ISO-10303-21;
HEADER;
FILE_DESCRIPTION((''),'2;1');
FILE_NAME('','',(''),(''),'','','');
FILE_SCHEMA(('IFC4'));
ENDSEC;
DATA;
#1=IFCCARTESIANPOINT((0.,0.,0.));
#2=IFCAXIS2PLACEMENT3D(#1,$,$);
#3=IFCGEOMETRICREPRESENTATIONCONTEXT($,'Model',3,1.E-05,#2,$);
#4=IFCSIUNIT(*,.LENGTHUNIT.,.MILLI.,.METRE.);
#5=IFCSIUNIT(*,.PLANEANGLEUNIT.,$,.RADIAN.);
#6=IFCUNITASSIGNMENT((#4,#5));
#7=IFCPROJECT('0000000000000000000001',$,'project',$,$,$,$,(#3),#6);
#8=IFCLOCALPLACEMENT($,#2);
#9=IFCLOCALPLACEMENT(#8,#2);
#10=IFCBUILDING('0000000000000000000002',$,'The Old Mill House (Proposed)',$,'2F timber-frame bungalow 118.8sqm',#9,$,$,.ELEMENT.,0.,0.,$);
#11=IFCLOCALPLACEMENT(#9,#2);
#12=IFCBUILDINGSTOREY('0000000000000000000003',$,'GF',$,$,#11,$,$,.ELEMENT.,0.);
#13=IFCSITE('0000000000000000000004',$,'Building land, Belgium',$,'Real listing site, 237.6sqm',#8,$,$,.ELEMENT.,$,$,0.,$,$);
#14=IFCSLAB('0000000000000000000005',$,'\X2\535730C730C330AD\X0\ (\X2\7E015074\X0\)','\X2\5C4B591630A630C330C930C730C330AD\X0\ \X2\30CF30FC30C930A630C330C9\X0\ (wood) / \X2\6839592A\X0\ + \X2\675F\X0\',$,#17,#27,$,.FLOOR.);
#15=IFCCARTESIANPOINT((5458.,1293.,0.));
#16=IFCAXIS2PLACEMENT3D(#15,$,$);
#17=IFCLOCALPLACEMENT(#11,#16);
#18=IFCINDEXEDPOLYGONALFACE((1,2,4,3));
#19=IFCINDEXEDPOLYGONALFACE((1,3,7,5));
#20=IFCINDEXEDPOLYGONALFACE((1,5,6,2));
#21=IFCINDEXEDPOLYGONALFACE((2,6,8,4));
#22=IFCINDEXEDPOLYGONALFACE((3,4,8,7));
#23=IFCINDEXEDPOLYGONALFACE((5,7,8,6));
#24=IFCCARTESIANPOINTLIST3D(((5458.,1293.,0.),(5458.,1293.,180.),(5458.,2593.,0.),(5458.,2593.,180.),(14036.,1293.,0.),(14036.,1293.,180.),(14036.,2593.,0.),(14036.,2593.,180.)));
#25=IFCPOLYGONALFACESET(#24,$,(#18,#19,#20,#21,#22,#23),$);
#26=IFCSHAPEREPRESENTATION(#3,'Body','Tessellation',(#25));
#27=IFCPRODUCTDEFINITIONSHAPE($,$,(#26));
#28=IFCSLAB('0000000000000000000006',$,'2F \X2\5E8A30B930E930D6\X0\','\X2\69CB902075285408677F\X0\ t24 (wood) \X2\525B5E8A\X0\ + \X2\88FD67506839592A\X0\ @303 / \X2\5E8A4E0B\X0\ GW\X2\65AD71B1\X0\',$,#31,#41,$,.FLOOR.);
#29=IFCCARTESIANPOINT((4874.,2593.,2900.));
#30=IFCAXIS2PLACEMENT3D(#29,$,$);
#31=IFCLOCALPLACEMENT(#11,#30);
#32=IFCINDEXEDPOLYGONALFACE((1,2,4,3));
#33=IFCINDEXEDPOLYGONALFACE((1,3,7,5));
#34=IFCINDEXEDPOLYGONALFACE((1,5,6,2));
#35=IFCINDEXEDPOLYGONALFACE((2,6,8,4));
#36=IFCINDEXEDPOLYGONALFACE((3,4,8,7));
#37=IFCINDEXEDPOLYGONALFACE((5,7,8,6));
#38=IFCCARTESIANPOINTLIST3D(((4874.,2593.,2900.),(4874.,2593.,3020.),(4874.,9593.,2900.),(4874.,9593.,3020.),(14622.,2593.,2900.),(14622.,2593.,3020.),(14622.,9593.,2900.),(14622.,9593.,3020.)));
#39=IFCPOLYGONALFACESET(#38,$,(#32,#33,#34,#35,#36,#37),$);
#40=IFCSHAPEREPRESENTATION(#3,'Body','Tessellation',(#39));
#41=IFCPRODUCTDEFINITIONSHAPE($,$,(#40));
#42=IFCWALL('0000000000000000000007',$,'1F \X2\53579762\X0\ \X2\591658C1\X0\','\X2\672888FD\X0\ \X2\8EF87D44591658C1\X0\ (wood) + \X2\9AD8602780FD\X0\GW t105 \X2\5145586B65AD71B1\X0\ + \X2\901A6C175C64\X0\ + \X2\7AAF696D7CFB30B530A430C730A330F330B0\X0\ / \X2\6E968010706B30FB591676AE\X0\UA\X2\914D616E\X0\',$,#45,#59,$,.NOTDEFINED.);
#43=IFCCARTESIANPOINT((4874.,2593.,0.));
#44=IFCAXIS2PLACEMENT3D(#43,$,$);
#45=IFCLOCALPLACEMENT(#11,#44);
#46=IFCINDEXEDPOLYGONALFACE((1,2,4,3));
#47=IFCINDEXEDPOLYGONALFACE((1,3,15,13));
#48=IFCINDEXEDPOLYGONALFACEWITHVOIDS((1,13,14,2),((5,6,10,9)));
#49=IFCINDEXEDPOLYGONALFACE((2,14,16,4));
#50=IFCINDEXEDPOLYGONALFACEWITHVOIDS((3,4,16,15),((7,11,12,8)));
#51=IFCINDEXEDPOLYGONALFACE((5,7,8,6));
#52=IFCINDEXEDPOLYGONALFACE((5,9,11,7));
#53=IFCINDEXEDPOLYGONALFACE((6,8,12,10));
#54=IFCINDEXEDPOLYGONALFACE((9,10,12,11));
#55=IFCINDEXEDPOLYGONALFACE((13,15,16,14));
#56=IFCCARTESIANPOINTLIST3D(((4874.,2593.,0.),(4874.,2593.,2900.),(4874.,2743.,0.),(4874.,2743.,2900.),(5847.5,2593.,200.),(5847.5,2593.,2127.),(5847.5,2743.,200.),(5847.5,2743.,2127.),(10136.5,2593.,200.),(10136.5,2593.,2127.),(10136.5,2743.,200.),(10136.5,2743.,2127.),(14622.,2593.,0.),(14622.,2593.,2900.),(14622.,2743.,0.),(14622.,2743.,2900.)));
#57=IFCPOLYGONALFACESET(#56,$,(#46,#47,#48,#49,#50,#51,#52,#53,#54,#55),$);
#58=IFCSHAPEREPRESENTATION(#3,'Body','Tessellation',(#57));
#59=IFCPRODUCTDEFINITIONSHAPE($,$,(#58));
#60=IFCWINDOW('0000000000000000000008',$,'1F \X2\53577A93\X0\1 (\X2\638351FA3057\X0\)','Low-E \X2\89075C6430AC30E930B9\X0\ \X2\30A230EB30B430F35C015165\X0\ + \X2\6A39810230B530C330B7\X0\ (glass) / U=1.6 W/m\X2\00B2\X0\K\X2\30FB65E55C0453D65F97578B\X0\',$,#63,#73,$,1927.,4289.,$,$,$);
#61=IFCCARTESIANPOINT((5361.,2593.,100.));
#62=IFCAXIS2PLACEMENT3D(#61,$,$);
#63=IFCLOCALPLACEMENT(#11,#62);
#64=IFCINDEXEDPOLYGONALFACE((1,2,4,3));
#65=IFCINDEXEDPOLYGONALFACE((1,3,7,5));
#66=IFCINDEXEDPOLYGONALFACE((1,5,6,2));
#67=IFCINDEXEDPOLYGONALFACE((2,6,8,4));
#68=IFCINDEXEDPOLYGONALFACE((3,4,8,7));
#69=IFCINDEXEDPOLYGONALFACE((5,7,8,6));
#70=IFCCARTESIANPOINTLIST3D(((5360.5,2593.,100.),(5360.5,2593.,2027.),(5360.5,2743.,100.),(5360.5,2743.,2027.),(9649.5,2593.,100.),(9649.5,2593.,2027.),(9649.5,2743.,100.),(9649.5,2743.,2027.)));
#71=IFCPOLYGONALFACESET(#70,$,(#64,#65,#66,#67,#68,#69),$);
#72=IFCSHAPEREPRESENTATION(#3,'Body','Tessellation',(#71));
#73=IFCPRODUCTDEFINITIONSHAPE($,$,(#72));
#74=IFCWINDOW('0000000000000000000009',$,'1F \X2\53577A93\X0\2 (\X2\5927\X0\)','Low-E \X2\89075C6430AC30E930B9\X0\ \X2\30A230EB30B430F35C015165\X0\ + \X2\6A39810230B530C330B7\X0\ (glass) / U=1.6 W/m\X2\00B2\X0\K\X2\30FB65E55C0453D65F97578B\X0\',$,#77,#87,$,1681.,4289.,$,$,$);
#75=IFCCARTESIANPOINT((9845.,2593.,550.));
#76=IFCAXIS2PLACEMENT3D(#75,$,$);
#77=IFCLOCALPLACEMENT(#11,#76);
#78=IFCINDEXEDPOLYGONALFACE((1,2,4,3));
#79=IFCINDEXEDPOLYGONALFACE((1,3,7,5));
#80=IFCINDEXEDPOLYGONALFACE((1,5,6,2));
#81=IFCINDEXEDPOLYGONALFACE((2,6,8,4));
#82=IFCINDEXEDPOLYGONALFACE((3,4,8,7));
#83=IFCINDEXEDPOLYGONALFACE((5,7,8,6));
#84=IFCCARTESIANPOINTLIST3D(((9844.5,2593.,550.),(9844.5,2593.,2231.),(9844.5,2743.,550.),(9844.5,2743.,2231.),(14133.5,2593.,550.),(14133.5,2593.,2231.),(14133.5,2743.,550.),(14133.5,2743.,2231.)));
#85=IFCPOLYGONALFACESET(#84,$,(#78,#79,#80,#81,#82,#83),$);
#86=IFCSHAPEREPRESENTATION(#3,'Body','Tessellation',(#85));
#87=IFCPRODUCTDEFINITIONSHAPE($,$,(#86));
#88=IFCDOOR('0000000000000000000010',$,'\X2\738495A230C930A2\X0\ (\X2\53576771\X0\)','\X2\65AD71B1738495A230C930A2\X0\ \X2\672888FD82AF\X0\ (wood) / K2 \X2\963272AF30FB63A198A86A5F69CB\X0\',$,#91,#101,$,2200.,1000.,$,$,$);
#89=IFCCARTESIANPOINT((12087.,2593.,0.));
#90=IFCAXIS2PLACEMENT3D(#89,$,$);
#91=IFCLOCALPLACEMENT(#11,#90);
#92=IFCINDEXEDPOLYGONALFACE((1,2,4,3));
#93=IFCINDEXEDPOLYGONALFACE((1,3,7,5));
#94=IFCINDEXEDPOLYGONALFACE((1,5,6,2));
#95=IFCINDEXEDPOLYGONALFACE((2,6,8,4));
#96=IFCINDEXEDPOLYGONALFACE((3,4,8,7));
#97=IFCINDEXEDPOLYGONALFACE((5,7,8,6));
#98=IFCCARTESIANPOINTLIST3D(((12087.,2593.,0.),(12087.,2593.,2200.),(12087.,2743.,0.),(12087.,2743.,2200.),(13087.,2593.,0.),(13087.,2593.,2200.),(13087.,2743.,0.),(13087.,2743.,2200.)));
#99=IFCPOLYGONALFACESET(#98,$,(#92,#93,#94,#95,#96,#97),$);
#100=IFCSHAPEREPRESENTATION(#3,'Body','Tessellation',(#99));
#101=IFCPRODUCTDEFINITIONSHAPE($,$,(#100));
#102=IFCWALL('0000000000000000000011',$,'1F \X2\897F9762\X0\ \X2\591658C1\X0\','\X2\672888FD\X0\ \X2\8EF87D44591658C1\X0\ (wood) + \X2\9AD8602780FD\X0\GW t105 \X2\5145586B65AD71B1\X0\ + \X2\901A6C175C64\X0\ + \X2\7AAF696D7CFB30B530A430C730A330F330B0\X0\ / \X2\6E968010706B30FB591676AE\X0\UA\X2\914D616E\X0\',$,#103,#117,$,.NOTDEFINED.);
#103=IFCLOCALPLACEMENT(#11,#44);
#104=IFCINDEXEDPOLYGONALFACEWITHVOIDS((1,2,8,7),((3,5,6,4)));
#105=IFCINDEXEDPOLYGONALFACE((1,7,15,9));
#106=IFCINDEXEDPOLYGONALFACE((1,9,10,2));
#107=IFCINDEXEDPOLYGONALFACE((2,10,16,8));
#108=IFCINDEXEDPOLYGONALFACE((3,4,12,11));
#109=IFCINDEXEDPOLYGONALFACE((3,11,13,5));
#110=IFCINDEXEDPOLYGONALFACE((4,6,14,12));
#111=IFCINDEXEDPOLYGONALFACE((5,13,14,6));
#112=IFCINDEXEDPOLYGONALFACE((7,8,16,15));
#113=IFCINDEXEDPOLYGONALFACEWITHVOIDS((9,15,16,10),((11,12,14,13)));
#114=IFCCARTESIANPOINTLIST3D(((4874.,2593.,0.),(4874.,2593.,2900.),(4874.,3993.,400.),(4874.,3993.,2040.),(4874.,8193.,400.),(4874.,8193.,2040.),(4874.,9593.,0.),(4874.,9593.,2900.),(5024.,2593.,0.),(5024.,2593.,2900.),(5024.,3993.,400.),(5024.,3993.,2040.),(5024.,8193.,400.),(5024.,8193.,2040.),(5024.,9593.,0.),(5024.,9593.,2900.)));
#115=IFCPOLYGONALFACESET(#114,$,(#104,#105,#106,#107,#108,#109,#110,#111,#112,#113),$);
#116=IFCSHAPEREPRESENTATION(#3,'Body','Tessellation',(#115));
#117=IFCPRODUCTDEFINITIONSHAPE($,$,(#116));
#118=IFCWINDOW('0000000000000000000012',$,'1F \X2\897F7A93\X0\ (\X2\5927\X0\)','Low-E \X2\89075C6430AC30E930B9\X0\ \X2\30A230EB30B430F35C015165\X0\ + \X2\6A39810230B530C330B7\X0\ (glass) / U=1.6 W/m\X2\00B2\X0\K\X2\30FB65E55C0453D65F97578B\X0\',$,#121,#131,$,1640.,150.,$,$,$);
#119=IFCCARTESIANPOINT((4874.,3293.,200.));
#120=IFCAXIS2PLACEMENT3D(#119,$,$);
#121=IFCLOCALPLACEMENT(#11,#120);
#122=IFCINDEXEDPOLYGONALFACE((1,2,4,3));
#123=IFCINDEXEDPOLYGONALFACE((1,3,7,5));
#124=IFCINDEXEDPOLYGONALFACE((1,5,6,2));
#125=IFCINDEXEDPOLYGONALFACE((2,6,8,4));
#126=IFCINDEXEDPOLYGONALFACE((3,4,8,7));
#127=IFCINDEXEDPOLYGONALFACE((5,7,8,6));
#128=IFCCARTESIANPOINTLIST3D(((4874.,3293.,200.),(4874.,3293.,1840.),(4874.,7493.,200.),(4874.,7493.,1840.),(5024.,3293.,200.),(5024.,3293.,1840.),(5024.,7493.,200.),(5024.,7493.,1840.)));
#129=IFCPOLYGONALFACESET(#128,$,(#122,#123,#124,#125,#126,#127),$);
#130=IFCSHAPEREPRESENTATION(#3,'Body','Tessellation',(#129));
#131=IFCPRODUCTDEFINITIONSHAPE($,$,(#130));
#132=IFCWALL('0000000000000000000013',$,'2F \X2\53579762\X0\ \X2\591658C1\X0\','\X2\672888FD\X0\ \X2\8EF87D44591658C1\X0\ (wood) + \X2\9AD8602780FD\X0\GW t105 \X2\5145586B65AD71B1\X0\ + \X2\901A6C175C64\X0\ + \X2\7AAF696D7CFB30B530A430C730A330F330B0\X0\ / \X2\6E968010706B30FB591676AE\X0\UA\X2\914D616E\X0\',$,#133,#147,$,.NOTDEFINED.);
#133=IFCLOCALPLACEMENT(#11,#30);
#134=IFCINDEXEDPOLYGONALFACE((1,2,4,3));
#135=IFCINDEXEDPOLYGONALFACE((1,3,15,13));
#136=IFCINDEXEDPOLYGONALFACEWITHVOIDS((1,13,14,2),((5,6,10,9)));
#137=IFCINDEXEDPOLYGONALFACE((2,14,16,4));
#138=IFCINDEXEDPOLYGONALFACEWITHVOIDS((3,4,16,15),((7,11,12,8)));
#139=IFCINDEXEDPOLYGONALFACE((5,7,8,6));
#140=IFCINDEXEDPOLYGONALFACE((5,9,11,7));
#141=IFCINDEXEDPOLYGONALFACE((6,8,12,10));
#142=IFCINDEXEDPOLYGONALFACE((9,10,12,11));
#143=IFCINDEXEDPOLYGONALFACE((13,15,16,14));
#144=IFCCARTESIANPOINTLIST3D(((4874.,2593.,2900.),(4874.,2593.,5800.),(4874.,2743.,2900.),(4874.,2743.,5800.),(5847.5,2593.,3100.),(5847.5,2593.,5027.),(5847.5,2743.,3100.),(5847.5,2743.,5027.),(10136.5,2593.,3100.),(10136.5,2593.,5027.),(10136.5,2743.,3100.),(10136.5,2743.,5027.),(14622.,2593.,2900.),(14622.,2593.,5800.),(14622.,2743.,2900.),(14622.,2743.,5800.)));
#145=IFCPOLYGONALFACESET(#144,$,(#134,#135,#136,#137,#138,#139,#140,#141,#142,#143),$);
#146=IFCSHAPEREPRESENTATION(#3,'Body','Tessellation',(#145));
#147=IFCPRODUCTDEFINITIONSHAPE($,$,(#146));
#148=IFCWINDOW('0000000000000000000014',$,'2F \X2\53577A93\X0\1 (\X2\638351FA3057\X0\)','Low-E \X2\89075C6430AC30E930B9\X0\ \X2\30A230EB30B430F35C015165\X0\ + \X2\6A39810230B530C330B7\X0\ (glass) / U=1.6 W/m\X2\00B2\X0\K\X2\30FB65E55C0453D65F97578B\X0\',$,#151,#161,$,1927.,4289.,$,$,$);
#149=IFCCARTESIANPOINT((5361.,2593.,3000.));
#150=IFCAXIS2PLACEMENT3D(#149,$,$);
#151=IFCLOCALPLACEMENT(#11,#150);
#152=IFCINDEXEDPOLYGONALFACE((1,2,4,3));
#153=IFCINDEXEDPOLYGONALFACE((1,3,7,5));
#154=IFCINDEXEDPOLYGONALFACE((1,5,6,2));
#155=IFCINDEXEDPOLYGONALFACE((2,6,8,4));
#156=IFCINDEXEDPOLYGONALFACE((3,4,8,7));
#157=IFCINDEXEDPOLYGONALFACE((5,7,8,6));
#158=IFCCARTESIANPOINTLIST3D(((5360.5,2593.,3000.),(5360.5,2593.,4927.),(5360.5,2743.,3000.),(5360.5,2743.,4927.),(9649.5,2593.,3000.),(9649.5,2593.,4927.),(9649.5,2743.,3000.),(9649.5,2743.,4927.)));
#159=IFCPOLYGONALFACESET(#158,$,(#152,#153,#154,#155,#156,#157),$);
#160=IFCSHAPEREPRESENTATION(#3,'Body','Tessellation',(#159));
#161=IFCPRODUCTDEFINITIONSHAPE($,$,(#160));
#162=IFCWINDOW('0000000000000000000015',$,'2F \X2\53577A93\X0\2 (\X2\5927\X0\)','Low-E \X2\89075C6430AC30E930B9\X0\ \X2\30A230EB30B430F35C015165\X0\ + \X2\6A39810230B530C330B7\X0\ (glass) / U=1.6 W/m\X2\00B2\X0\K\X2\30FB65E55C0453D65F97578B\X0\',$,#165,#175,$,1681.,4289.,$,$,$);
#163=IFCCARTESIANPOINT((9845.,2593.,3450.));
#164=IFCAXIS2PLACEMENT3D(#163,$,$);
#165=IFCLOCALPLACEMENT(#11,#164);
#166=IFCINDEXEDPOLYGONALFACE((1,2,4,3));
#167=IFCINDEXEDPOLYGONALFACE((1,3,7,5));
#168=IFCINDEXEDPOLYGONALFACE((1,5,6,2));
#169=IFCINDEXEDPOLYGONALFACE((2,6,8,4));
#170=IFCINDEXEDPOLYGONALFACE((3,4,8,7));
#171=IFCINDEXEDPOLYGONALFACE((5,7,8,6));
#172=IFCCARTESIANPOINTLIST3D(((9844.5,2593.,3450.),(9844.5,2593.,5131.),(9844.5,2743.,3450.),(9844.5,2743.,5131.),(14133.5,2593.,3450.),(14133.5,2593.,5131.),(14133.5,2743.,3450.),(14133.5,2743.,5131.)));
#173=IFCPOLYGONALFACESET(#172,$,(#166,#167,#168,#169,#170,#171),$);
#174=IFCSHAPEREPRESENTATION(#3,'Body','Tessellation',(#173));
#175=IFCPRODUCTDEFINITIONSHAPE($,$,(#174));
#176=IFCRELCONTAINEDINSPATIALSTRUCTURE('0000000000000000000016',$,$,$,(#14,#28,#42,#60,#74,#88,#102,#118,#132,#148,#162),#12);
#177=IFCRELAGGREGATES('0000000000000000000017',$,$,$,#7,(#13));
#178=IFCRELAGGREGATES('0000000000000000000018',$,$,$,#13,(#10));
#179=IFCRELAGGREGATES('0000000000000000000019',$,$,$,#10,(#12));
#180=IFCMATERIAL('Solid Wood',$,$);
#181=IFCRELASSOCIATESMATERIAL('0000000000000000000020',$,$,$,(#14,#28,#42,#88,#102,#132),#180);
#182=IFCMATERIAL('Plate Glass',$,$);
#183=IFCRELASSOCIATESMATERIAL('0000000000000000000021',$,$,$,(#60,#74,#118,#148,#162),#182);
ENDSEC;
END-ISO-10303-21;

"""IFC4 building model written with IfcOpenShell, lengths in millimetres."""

from ifc_helpers import new_model, si_unit, frame, frame_2d, origin, place, context, project, spatial, rectangle, extrude, material, element, fill, save


model = new_model("IFC4")

# Units and contexts
model_context = context("Model", 3, precision=1e-05, world=origin())
ifc_project = project(units=[si_unit("LENGTHUNIT", "METRE", prefix="MILLI"), si_unit("PLANEANGLEUNIT", "RADIAN")], contexts=[model_context])

# Site, building, storey
site_placement = place(None, origin())
site = spatial("IfcSite", under=ifc_project, at=site_placement, Name="Building land, Belgium", ObjectType="Real listing site, 237.6sqm", CompositionType="ELEMENT", RefElevation=0.0)
building_placement = place(site_placement, origin())
building = spatial("IfcBuilding", under=site, at=building_placement, Name="The Old Mill House (Proposed)", ObjectType="2F timber-frame bungalow 118.8sqm", CompositionType="ELEMENT", ElevationOfRefHeight=0.0, ElevationOfTerrain=0.0)
storey_placement = place(building_placement, origin())
storey = spatial("IfcBuildingStorey", under=building, at=storey_placement, Name="GF", CompositionType="ELEMENT", Elevation=0.0)

# Slabs
ifc_material_1 = material(Name="Solid Wood")
slab_1_placement = place(storey_placement, frame((5458.0, 1293.0, 0.0)))
element("IfcSlab", 1, at=slab_1_placement, inside=storey, material=ifc_material_1, Name="南デッキ (縁側)", Description="屋外ウッドデッキ ハードウッド (wood) / 根太 + 束", PredefinedType="FLOOR", context=model_context, shape_type="SweptSolid", body=[
    extrude(rectangle(XDim=8578.0, YDim=1300.0, at=frame_2d((4289.0, 650.0))), frame((5458.0, 1293.0, 0.0)), (0.0, 0.0, 1.0), 180.0),
])
slab_2_placement = place(storey_placement, frame((4874.0, 2593.0, 2900.0)))
element("IfcSlab", 2, at=slab_2_placement, inside=storey, material=ifc_material_1, Name="2F 床スラブ", Description="構造用合板 t24 (wood) 剛床 + 製材根太 @303 / 床下 GW断熱", PredefinedType="FLOOR", context=model_context, shape_type="SweptSolid", body=[
    extrude(rectangle(XDim=9748.0, YDim=7000.0, at=frame_2d((4874.0, 3500.0))), frame((4874.0, 2593.0, 2900.0)), (0.0, 0.0, 1.0), 120.0),
])

# Wall, openings, windows, door
wall_1_placement = place(storey_placement, frame((4874.0, 2593.0, 0.0)))
wall_1 = element("IfcWall", 3, at=wall_1_placement, inside=storey, material=ifc_material_1, Name="1F 南面 外壁", Description="木製 軸組外壁 (wood) + 高性能GW t105 充填断熱 + 通気層 + 窯業系サイディング / 準耐火・外皮UA配慮", PredefinedType="NOTDEFINED", context=model_context, shape_type="SweptSolid", body=[
    extrude(rectangle(XDim=9748.0, YDim=150.0, at=frame_2d((4874.0, 75.0))), frame((4874.0, 2593.0, 0.0)), (0.0, 0.0, 1.0), 2900.0),
])
opening_1_placement = place(storey_placement, frame((5361.0, 2593.0, 100.0)))
opening_1 = element("IfcOpeningElement", 4, at=opening_1_placement, cuts=wall_1, PredefinedType="NOTDEFINED", context=model_context, shape_type="SweptSolid", body=[
    extrude(rectangle(XDim=4289.0, YDim=150.0, at=frame_2d((2144.0, 75.0))), frame((5361.0, 2593.0, 100.0)), (0.0, 0.0, 1.0), 1927.0),
])
opening_2_placement = place(storey_placement, frame((9845.0, 2593.0, 550.0)))
opening_2 = element("IfcOpeningElement", 5, at=opening_2_placement, cuts=wall_1, PredefinedType="NOTDEFINED", context=model_context, shape_type="SweptSolid", body=[
    extrude(rectangle(XDim=4289.0, YDim=150.0, at=frame_2d((2144.0, 75.0))), frame((9845.0, 2593.0, 550.0)), (0.0, 0.0, 1.0), 1681.0),
])
opening_3_placement = place(storey_placement, frame((12087.0, 2593.0, 0.0)))
opening_3 = element("IfcOpeningElement", 6, at=opening_3_placement, cuts=wall_1, PredefinedType="NOTDEFINED", context=model_context, shape_type="SweptSolid", body=[
    extrude(rectangle(XDim=1000.0, YDim=150.0, at=frame_2d((500.0, 75.0))), frame((12087.0, 2593.0, 0.0)), (0.0, 0.0, 1.0), 2200.0),
])
ifc_material_2 = material(Name="Plate Glass")
window_1_placement = place(storey_placement, frame((5361.0, 2593.0, 100.0)))
window_1 = element("IfcWindow", 7, at=window_1_placement, inside=storey, material=ifc_material_2, Name="1F 南窓1 (掃出し)", Description="Low-E 複層ガラス アルゴン封入 + 樹脂サッシ (glass) / U=1.6 W/m²K・日射取得型", OverallHeight=1927.0, OverallWidth=4289.0, context=model_context, shape_type="SweptSolid", body=[
    extrude(rectangle(XDim=4289.0, YDim=150.0, at=frame_2d((2144.0, 75.0))), frame((5361.0, 2593.0, 100.0)), (0.0, 0.0, 1.0), 1927.0),
])
fill(opening_1, window_1)
window_2_placement = place(storey_placement, frame((9845.0, 2593.0, 550.0)))
window_2 = element("IfcWindow", 8, at=window_2_placement, inside=storey, material=ifc_material_2, Name="1F 南窓2 (大)", Description="Low-E 複層ガラス アルゴン封入 + 樹脂サッシ (glass) / U=1.6 W/m²K・日射取得型", OverallHeight=1681.0, OverallWidth=4289.0, context=model_context, shape_type="SweptSolid", body=[
    extrude(rectangle(XDim=4289.0, YDim=150.0, at=frame_2d((2144.0, 75.0))), frame((9845.0, 2593.0, 550.0)), (0.0, 0.0, 1.0), 1681.0),
])
fill(opening_2, window_2)
door_placement = place(storey_placement, frame((12087.0, 2593.0, 0.0)))
door = element("IfcDoor", 9, at=door_placement, inside=storey, material=ifc_material_1, Name="玄関ドア (南東)", Description="断熱玄関ドア 木製芯 (wood) / K2 防犯・採風機構", OverallHeight=2200.0, OverallWidth=1000.0, context=model_context, shape_type="SweptSolid", body=[
    extrude(rectangle(XDim=1000.0, YDim=150.0, at=frame_2d((500.0, 75.0))), frame((12087.0, 2593.0, 0.0)), (0.0, 0.0, 1.0), 2200.0),
])
fill(opening_3, door)

# Wall, opening, window
wall_2_placement = place(storey_placement, frame((4874.0, 2593.0, 0.0)))
wall_2 = element("IfcWall", 10, at=wall_2_placement, inside=storey, material=ifc_material_1, Name="1F 西面 外壁", Description="木製 軸組外壁 (wood) + 高性能GW t105 充填断熱 + 通気層 + 窯業系サイディング / 準耐火・外皮UA配慮", PredefinedType="NOTDEFINED", context=model_context, shape_type="SweptSolid", body=[
    extrude(rectangle(XDim=150.0, YDim=7000.0, at=frame_2d((75.0, 3500.0))), frame((4874.0, 2593.0, 0.0)), (0.0, 0.0, 1.0), 2900.0),
])
opening_4_placement = place(storey_placement, frame((4874.0, 3293.0, 200.0)))
opening_4 = element("IfcOpeningElement", 11, at=opening_4_placement, cuts=wall_2, PredefinedType="NOTDEFINED", context=model_context, shape_type="SweptSolid", body=[
    extrude(rectangle(XDim=150.0, YDim=4200.0, at=frame_2d((75.0, 2100.0))), frame((4874.0, 3293.0, 200.0)), (0.0, 0.0, 1.0), 1640.0),
])
window_3_placement = place(storey_placement, frame((4874.0, 3293.0, 200.0)))
window_3 = element("IfcWindow", 12, at=window_3_placement, inside=storey, material=ifc_material_2, Name="1F 西窓 (大)", Description="Low-E 複層ガラス アルゴン封入 + 樹脂サッシ (glass) / U=1.6 W/m²K・日射取得型", OverallHeight=1640.0, OverallWidth=150.0, context=model_context, shape_type="SweptSolid", body=[
    extrude(rectangle(XDim=150.0, YDim=4200.0, at=frame_2d((75.0, 2100.0))), frame((4874.0, 3293.0, 200.0)), (0.0, 0.0, 1.0), 1640.0),
])
fill(opening_4, window_3)

# Wall, openings, windows
wall_3_placement = place(storey_placement, frame((4874.0, 2593.0, 2900.0)))
wall_3 = element("IfcWall", 13, at=wall_3_placement, inside=storey, material=ifc_material_1, Name="2F 南面 外壁", Description="木製 軸組外壁 (wood) + 高性能GW t105 充填断熱 + 通気層 + 窯業系サイディング / 準耐火・外皮UA配慮", PredefinedType="NOTDEFINED", context=model_context, shape_type="SweptSolid", body=[
    extrude(rectangle(XDim=9748.0, YDim=150.0, at=frame_2d((4874.0, 75.0))), frame((4874.0, 2593.0, 2900.0)), (0.0, 0.0, 1.0), 2900.0),
])
opening_5_placement = place(storey_placement, frame((5361.0, 2593.0, 3000.0)))
opening_5 = element("IfcOpeningElement", 14, at=opening_5_placement, cuts=wall_3, PredefinedType="NOTDEFINED", context=model_context, shape_type="SweptSolid", body=[
    extrude(rectangle(XDim=4289.0, YDim=150.0, at=frame_2d((2144.0, 75.0))), frame((5361.0, 2593.0, 3000.0)), (0.0, 0.0, 1.0), 1927.0),
])
opening_6_placement = place(storey_placement, frame((9845.0, 2593.0, 3450.0)))
opening_6 = element("IfcOpeningElement", 15, at=opening_6_placement, cuts=wall_3, PredefinedType="NOTDEFINED", context=model_context, shape_type="SweptSolid", body=[
    extrude(rectangle(XDim=4289.0, YDim=150.0, at=frame_2d((2144.0, 75.0))), frame((9845.0, 2593.0, 3450.0)), (0.0, 0.0, 1.0), 1681.0),
])
window_4_placement = place(storey_placement, frame((5361.0, 2593.0, 3000.0)))
window_4 = element("IfcWindow", 16, at=window_4_placement, inside=storey, material=ifc_material_2, Name="2F 南窓1 (掃出し)", Description="Low-E 複層ガラス アルゴン封入 + 樹脂サッシ (glass) / U=1.6 W/m²K・日射取得型", OverallHeight=1927.0, OverallWidth=4289.0, context=model_context, shape_type="SweptSolid", body=[
    extrude(rectangle(XDim=4289.0, YDim=150.0, at=frame_2d((2144.0, 75.0))), frame((5361.0, 2593.0, 3000.0)), (0.0, 0.0, 1.0), 1927.0),
])
fill(opening_5, window_4)
window_5_placement = place(storey_placement, frame((9845.0, 2593.0, 3450.0)))
window_5 = element("IfcWindow", 17, at=window_5_placement, inside=storey, material=ifc_material_2, Name="2F 南窓2 (大)", Description="Low-E 複層ガラス アルゴン封入 + 樹脂サッシ (glass) / U=1.6 W/m²K・日射取得型", OverallHeight=1681.0, OverallWidth=4289.0, context=model_context, shape_type="SweptSolid", body=[
    extrude(rectangle(XDim=4289.0, YDim=150.0, at=frame_2d((2144.0, 75.0))), frame((9845.0, 2593.0, 3450.0)), (0.0, 0.0, 1.0), 1681.0),
])
fill(opening_6, window_5)

save(model, "model.ifc")
